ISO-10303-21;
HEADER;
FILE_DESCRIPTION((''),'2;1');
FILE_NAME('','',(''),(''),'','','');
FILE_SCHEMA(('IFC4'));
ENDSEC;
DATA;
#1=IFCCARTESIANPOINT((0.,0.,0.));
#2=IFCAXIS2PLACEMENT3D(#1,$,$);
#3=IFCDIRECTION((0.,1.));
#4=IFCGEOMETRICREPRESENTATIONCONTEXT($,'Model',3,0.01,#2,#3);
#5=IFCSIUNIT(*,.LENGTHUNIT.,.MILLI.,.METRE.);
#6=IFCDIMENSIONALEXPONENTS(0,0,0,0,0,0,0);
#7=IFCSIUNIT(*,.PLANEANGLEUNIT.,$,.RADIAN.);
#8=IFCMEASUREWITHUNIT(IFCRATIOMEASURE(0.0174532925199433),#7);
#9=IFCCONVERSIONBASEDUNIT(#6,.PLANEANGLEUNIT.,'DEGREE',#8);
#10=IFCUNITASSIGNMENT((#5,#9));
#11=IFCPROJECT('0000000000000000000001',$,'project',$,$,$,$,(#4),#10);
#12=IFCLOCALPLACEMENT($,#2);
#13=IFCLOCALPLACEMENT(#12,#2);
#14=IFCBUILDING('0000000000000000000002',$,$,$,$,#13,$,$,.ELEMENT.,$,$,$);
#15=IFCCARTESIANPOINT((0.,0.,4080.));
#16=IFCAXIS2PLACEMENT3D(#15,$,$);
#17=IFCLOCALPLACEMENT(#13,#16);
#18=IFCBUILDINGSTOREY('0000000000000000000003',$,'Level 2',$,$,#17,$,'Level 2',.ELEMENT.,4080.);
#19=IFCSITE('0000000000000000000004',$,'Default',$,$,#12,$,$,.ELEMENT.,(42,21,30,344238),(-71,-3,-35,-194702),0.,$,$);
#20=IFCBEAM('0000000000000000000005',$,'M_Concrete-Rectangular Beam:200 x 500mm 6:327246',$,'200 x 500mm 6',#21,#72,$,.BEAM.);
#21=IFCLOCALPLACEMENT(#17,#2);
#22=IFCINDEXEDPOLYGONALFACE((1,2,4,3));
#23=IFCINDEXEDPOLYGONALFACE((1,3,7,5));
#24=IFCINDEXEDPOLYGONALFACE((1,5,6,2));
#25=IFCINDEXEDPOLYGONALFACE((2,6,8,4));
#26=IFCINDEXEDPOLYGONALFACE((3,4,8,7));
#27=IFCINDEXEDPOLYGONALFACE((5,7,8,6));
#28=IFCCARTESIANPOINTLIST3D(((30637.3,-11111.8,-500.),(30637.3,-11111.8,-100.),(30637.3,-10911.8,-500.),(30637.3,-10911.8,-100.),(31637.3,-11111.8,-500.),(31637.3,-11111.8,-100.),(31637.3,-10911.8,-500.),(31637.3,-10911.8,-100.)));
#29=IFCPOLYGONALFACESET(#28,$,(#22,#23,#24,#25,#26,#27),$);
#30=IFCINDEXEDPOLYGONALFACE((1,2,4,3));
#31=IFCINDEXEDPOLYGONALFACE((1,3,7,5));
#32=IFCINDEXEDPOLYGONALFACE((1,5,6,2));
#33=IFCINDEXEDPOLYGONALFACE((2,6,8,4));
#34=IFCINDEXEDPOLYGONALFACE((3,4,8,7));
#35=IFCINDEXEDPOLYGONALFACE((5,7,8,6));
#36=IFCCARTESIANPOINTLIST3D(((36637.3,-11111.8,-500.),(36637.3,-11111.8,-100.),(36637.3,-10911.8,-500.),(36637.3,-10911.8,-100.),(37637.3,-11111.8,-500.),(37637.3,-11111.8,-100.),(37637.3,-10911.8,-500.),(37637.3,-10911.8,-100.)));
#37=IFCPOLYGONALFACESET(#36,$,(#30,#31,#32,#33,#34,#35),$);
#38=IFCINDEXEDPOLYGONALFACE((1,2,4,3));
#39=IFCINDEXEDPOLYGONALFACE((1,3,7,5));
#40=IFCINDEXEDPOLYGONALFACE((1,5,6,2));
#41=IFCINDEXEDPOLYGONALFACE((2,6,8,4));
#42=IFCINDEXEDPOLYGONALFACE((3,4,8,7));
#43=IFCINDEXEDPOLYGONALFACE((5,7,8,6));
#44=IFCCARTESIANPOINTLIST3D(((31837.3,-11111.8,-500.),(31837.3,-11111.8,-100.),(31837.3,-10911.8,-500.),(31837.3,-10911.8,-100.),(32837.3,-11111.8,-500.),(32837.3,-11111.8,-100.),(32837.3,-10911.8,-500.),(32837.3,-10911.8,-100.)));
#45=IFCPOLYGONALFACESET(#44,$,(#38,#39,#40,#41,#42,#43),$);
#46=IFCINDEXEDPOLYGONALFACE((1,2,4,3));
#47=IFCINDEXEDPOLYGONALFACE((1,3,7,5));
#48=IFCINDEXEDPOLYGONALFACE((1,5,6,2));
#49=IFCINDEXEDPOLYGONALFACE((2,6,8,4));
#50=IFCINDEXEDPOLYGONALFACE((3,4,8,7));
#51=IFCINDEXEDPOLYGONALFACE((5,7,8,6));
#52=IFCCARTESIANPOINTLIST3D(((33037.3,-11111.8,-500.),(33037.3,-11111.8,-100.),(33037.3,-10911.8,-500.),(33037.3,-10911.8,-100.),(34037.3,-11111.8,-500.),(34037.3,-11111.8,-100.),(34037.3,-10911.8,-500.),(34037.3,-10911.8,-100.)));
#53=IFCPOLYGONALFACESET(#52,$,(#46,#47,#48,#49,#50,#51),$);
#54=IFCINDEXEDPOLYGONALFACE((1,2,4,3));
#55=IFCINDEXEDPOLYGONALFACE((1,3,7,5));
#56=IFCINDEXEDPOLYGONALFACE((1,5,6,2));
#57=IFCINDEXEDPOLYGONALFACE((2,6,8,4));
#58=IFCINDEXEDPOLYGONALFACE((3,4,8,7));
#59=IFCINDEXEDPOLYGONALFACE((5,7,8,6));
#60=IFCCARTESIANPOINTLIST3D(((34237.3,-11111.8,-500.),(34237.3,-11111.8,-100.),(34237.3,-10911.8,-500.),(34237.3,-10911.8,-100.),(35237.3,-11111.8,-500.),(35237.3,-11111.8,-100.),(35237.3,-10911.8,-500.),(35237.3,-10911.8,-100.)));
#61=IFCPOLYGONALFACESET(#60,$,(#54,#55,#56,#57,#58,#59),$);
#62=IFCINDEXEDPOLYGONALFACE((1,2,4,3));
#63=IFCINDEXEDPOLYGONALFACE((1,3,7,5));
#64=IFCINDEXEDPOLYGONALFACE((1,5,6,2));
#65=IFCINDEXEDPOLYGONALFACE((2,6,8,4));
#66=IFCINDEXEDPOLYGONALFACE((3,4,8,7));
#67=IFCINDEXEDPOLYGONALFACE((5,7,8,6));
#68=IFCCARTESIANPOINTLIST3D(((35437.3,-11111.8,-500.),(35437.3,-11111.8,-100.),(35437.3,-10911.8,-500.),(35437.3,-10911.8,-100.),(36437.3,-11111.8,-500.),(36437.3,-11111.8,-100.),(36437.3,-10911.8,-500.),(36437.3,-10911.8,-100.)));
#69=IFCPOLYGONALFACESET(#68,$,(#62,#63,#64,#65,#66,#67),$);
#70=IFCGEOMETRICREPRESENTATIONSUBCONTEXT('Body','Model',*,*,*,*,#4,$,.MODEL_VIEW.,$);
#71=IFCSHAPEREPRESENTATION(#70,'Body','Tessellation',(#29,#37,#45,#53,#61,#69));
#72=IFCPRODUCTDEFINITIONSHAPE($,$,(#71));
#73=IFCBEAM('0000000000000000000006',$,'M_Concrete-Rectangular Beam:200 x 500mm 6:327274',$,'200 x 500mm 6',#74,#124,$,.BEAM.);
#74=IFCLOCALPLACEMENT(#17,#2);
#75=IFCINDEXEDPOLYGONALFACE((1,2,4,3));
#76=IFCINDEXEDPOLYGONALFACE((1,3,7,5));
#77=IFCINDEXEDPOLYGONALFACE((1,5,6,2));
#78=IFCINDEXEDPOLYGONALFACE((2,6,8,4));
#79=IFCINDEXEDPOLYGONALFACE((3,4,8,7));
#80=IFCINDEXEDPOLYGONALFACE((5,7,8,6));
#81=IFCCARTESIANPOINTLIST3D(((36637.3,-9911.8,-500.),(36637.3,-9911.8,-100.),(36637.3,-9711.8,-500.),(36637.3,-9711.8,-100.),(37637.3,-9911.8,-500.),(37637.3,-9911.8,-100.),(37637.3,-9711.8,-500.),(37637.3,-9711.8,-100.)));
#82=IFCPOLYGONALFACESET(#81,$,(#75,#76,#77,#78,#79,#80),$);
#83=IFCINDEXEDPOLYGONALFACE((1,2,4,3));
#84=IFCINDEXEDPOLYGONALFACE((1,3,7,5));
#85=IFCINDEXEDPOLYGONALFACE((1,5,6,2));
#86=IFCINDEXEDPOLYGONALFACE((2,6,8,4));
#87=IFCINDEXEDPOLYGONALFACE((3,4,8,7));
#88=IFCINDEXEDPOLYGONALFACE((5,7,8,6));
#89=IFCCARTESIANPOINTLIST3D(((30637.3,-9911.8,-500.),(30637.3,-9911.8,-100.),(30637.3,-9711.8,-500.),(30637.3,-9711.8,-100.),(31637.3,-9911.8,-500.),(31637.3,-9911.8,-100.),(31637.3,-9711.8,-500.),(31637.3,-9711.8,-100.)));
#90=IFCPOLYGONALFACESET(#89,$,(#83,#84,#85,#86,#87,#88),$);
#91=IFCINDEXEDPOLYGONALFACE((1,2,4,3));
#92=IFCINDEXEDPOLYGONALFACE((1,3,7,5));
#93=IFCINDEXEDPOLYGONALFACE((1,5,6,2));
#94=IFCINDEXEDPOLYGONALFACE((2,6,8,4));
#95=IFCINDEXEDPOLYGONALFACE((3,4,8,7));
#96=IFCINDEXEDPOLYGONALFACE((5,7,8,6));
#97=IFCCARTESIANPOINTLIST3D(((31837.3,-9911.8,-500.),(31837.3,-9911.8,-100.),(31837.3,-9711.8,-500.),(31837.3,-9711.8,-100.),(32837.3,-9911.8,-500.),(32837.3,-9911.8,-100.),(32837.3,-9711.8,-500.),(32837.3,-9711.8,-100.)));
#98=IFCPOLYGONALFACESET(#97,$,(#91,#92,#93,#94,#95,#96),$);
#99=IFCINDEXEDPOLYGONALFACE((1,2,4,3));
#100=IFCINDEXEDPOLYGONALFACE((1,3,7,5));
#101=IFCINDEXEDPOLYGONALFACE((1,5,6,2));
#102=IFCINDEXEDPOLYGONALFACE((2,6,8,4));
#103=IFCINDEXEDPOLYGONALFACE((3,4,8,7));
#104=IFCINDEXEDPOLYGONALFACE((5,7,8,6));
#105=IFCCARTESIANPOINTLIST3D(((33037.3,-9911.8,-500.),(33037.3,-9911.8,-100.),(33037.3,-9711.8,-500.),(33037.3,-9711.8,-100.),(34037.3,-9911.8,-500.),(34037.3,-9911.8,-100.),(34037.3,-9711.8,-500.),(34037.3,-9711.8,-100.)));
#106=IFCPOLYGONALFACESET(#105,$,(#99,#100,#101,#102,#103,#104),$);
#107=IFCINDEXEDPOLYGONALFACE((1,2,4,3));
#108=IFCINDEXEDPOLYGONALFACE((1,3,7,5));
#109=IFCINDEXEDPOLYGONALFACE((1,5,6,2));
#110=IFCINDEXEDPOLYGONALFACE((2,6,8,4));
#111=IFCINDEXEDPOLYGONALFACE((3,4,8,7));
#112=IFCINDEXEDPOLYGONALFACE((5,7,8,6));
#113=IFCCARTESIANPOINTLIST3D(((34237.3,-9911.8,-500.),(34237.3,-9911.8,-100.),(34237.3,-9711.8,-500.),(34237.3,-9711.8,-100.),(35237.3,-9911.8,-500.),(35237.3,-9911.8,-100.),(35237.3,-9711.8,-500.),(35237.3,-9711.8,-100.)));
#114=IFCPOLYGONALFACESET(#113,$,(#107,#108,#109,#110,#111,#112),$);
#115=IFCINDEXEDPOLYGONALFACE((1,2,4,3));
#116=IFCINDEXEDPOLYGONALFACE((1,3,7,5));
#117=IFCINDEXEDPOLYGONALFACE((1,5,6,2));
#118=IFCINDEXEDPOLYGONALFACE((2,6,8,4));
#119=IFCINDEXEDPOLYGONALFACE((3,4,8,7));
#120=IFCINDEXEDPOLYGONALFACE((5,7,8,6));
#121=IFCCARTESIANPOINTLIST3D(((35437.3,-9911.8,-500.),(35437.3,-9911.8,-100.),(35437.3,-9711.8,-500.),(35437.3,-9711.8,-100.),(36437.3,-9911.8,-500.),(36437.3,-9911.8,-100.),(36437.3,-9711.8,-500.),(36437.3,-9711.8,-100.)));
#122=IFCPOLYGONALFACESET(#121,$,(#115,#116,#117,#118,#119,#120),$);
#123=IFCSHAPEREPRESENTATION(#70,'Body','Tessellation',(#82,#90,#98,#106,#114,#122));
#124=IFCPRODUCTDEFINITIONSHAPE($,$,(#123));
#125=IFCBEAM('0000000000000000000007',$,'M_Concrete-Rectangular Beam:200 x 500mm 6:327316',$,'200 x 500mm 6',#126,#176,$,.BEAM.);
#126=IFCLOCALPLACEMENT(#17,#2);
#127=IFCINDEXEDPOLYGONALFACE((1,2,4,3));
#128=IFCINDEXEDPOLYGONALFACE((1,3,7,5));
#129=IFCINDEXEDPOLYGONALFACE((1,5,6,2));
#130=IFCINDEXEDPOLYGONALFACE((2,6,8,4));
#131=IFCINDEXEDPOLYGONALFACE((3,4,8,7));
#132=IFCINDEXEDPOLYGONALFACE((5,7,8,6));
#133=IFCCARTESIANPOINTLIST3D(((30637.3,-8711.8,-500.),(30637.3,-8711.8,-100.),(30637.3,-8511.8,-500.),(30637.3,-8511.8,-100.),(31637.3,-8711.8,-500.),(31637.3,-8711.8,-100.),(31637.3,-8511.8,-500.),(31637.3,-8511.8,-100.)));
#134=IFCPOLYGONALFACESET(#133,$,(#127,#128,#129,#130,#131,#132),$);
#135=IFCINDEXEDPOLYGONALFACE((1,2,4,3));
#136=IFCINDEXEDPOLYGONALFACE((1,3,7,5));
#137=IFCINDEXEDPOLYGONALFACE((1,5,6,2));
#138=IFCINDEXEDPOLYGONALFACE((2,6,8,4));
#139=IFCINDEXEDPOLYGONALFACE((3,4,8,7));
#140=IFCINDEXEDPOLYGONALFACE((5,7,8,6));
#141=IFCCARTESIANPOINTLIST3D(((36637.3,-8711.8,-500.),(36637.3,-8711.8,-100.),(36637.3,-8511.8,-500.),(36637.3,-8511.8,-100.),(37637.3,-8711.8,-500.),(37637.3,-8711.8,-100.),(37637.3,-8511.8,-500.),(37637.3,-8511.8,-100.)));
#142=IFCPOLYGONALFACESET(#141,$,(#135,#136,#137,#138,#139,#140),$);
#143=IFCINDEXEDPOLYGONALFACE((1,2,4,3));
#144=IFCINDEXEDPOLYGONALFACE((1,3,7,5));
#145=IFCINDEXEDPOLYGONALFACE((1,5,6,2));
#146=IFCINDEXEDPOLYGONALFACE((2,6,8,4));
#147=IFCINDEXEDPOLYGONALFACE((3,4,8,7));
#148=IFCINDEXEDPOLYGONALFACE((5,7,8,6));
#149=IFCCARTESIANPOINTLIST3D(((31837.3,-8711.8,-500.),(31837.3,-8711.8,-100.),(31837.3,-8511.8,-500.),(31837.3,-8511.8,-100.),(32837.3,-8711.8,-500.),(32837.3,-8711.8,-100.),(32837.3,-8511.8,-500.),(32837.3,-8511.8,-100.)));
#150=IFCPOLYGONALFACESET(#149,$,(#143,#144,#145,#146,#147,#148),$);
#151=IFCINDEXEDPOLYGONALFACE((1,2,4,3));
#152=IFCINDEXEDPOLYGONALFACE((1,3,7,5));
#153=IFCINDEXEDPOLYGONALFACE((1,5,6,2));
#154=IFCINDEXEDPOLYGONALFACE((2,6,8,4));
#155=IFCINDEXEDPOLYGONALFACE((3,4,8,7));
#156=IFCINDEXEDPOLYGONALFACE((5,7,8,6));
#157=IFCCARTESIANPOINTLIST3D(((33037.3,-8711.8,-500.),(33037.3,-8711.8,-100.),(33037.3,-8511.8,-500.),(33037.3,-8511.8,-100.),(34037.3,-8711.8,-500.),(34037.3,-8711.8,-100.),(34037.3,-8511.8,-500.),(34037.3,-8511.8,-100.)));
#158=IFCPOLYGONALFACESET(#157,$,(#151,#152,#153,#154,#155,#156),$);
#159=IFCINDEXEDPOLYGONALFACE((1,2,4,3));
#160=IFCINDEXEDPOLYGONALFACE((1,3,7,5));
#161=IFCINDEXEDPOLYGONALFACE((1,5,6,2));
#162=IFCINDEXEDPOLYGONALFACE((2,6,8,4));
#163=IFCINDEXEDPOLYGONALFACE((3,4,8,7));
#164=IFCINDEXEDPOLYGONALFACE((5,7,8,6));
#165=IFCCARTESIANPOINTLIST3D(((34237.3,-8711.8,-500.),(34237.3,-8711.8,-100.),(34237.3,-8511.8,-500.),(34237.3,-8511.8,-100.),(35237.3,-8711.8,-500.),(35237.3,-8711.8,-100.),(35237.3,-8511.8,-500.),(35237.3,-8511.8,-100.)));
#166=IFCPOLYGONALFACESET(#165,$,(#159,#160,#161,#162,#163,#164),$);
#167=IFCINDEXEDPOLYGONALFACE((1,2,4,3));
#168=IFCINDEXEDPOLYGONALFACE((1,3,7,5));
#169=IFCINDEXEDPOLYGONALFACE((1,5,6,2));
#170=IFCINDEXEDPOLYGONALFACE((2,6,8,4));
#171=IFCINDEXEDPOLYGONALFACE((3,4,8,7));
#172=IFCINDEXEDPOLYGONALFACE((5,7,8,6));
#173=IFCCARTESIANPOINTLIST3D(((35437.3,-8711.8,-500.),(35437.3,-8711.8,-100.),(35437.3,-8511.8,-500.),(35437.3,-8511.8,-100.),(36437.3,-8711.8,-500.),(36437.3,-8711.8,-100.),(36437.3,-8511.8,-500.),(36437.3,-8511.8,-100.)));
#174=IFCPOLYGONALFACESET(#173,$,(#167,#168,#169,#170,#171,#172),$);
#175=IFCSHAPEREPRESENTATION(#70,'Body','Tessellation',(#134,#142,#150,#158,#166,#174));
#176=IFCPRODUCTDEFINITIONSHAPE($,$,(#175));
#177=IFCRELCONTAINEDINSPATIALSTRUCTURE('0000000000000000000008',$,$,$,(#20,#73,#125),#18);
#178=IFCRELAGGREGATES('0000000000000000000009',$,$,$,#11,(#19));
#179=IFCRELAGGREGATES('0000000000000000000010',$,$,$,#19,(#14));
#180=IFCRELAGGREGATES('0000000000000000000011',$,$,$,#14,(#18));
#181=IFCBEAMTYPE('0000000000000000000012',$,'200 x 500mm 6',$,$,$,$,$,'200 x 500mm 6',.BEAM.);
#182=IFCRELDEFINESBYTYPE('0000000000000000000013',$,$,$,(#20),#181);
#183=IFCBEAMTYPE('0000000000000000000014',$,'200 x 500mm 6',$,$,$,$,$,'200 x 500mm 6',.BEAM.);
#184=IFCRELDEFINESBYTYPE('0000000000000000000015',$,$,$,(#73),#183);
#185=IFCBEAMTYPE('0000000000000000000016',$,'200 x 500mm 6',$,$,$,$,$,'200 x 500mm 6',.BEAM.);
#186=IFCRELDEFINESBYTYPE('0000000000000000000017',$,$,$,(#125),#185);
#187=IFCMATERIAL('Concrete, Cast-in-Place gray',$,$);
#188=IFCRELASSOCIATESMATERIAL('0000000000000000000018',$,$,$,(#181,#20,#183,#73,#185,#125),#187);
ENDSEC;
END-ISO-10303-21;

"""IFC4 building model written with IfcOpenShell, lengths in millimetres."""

from ifc_helpers import new_model, entity, si_unit, converted_unit, direction, frame, frame_2d, origin, origin_2d_with_axis, place, context, subcontext, project, spatial, rectangle, extrude, source, transform, mapped, material, type_object, type_shapes, element, save


model = new_model("IFC4")

# Units and contexts
model_context = context("Model", 3, precision=0.01, world=origin(), true_north=direction((0.0, 1.0)))
body_context = subcontext(model_context, "Body", "Model", "MODEL_VIEW")
ifc_project = project(units=[si_unit("LENGTHUNIT", "METRE", prefix="MILLI"), converted_unit("PLANEANGLEUNIT", "DEGREE", entity("IfcRatioMeasure", 0.0174532925199433), si_unit("PLANEANGLEUNIT", "RADIAN"), dimensions=[0, 0, 0, 0, 0, 0, 0])], contexts=[model_context])

# Site, building, storey
site_placement = place(None, origin())
site = spatial("IfcSite", under=ifc_project, at=site_placement, Name="Default", CompositionType="ELEMENT", RefLatitude=(42, 21, 30, 344238), RefLongitude=(-71, -3, -35, -194702), RefElevation=0.0)
building_placement = place(site_placement, origin())
building = spatial("IfcBuilding", under=site, at=building_placement, CompositionType="ELEMENT")
storey_placement = place(building_placement, frame((0.0, 0.0, 4080.0)))
storey = spatial("IfcBuildingStorey", under=building, at=storey_placement, Name="Level 2", LongName="Level 2", CompositionType="ELEMENT", Elevation=4080.0)

# Beams
ifc_material = material(Name="Concrete, Cast-in-Place gray")
beam_type_1 = type_object("IfcBeamType", Name="200 x 500mm 6", ElementType="200 x 500mm 6", PredefinedType="BEAM", material=ifc_material)
shared_shape_1 = source(origin(), body_context, "Body", "SweptSolid", [
    extrude(rectangle(XDim=1000.0, YDim=200.0, at=origin_2d_with_axis()), frame((31137.3, -11011.8, 3580.0)), (0.0, 0.0, 1.0), 400.0),
    extrude(rectangle(XDim=1000.0, YDim=200.0, at=origin_2d_with_axis()), frame((37137.3, -11011.8, 3580.0), z_axis=(0.0, 0.0, 1.0), x_axis=(-1.0, 0.0, 0.0)), (0.0, 0.0, 1.0), 400.0),
    extrude(rectangle(XDim=1000.0, YDim=200.0, at=frame_2d((0.0, 0.0), x_axis=(1.0, 0.0))), frame((32337.3, -11011.8, 3580.0)), (0.0, 0.0, 1.0), 400.0),
    extrude(rectangle(XDim=1000.0, YDim=200.0, at=frame_2d((0.0, 0.0), x_axis=(1.0, 0.0))), frame((33537.3, -11011.8, 3580.0)), (0.0, 0.0, 1.0), 400.0),
    extrude(rectangle(XDim=1000.0, YDim=200.0, at=origin_2d_with_axis()), frame((34737.3, -11011.8, 3580.0)), (0.0, 0.0, 1.0), 400.0),
    extrude(rectangle(XDim=1000.0, YDim=200.0, at=frame_2d((0.0, 0.0), x_axis=(1.0, 0.0))), frame((35937.3, -11011.8, 3580.0)), (0.0, 0.0, 1.0), 400.0),
])
type_shapes(beam_type_1, [shared_shape_1])
beam_1_placement = place(storey_placement, frame((0.0, 0.0, -4080.0)))
element("IfcBeam", 1, at=beam_1_placement, inside=storey, type_object=beam_type_1, material=ifc_material, Name="M_Concrete-Rectangular Beam:200 x 500mm 6:327246", ObjectType="200 x 500mm 6", PredefinedType="BEAM", context=body_context, shape_type="MappedRepresentation", body=[
    mapped(shared_shape_1, transform((0.0, 0.0, 0.0), scale=1.0)),
])
beam_type_2 = type_object("IfcBeamType", Name="200 x 500mm 6", ElementType="200 x 500mm 6", PredefinedType="BEAM", material=ifc_material)
shared_shape_2 = source(origin(), body_context, "Body", "SweptSolid", [
    extrude(rectangle(XDim=1000.0, YDim=200.0, at=frame_2d((0.0, 0.0), x_axis=(1.0, 0.0))), frame((37137.3, -9811.8, 3580.0), z_axis=(0.0, 0.0, 1.0), x_axis=(-1.0, 0.0, 0.0)), (0.0, 0.0, 1.0), 400.0),
    extrude(rectangle(XDim=1000.0, YDim=200.0, at=frame_2d((0.0, 0.0), x_axis=(1.0, 0.0))), frame((31137.3, -9811.8, 3580.0)), (0.0, 0.0, 1.0), 400.0),
    extrude(rectangle(XDim=1000.0, YDim=200.0, at=frame_2d((0.0, 0.0), x_axis=(1.0, 0.0))), frame((32337.3, -9811.8, 3580.0)), (0.0, 0.0, 1.0), 400.0),
    extrude(rectangle(XDim=1000.0, YDim=200.0, at=frame_2d((0.0, 0.0), x_axis=(1.0, 0.0))), frame((33537.3, -9811.8, 3580.0)), (0.0, 0.0, 1.0), 400.0),
    extrude(rectangle(XDim=1000.0, YDim=200.0, at=frame_2d((0.0, 0.0), x_axis=(1.0, 0.0))), frame((34737.3, -9811.8, 3580.0)), (0.0, 0.0, 1.0), 400.0),
    extrude(rectangle(XDim=1000.0, YDim=200.0, at=frame_2d((0.0, 0.0), x_axis=(1.0, 0.0))), frame((35937.3, -9811.8, 3580.0)), (0.0, 0.0, 1.0), 400.0),
])
type_shapes(beam_type_2, [shared_shape_2])
beam_2_placement = place(storey_placement, frame((0.0, 0.0, -4080.0)))
element("IfcBeam", 2, at=beam_2_placement, inside=storey, type_object=beam_type_2, material=ifc_material, Name="M_Concrete-Rectangular Beam:200 x 500mm 6:327274", ObjectType="200 x 500mm 6", PredefinedType="BEAM", context=body_context, shape_type="MappedRepresentation", body=[
    mapped(shared_shape_2, transform((0.0, 0.0, 0.0), scale=1.0)),
])
beam_type_3 = type_object("IfcBeamType", Name="200 x 500mm 6", ElementType="200 x 500mm 6", PredefinedType="BEAM", material=ifc_material)
shared_shape_3 = source(origin(), body_context, "Body", "SweptSolid", [
    extrude(rectangle(XDim=1000.0, YDim=200.0, at=frame_2d((0.0, 0.0), x_axis=(1.0, 0.0))), frame((31137.3, -8611.8, 3580.0)), (0.0, 0.0, 1.0), 400.0),
    extrude(rectangle(XDim=1000.0, YDim=200.0, at=frame_2d((0.0, 0.0), x_axis=(1.0, 0.0))), frame((37137.3, -8611.8, 3580.0), z_axis=(0.0, 0.0, 1.0), x_axis=(-1.0, 0.0, 0.0)), (0.0, 0.0, 1.0), 400.0),
    extrude(rectangle(XDim=1000.0, YDim=200.0, at=frame_2d((0.0, 0.0), x_axis=(1.0, 0.0))), frame((32337.3, -8611.8, 3580.0)), (0.0, 0.0, 1.0), 400.0),
    extrude(rectangle(XDim=1000.0, YDim=200.0, at=frame_2d((0.0, 0.0), x_axis=(1.0, 0.0))), frame((33537.3, -8611.8, 3580.0)), (0.0, 0.0, 1.0), 400.0),
    extrude(rectangle(XDim=1000.0, YDim=200.0, at=origin_2d_with_axis()), frame((34737.3, -8611.8, 3580.0)), (0.0, 0.0, 1.0), 400.0),
    extrude(rectangle(XDim=1000.0, YDim=200.0, at=frame_2d((0.0, 0.0), x_axis=(1.0, 0.0))), frame((35937.3, -8611.8, 3580.0)), (0.0, 0.0, 1.0), 400.0),
])
type_shapes(beam_type_3, [shared_shape_3])
beam_3_placement = place(storey_placement, frame((0.0, 0.0, -4080.0)))
element("IfcBeam", 3, at=beam_3_placement, inside=storey, type_object=beam_type_3, material=ifc_material, Name="M_Concrete-Rectangular Beam:200 x 500mm 6:327316", ObjectType="200 x 500mm 6", PredefinedType="BEAM", context=body_context, shape_type="MappedRepresentation", body=[
    mapped(shared_shape_3, transform((0.0, 0.0, 0.0), scale=1.0)),
])

save(model, "model.ifc")
